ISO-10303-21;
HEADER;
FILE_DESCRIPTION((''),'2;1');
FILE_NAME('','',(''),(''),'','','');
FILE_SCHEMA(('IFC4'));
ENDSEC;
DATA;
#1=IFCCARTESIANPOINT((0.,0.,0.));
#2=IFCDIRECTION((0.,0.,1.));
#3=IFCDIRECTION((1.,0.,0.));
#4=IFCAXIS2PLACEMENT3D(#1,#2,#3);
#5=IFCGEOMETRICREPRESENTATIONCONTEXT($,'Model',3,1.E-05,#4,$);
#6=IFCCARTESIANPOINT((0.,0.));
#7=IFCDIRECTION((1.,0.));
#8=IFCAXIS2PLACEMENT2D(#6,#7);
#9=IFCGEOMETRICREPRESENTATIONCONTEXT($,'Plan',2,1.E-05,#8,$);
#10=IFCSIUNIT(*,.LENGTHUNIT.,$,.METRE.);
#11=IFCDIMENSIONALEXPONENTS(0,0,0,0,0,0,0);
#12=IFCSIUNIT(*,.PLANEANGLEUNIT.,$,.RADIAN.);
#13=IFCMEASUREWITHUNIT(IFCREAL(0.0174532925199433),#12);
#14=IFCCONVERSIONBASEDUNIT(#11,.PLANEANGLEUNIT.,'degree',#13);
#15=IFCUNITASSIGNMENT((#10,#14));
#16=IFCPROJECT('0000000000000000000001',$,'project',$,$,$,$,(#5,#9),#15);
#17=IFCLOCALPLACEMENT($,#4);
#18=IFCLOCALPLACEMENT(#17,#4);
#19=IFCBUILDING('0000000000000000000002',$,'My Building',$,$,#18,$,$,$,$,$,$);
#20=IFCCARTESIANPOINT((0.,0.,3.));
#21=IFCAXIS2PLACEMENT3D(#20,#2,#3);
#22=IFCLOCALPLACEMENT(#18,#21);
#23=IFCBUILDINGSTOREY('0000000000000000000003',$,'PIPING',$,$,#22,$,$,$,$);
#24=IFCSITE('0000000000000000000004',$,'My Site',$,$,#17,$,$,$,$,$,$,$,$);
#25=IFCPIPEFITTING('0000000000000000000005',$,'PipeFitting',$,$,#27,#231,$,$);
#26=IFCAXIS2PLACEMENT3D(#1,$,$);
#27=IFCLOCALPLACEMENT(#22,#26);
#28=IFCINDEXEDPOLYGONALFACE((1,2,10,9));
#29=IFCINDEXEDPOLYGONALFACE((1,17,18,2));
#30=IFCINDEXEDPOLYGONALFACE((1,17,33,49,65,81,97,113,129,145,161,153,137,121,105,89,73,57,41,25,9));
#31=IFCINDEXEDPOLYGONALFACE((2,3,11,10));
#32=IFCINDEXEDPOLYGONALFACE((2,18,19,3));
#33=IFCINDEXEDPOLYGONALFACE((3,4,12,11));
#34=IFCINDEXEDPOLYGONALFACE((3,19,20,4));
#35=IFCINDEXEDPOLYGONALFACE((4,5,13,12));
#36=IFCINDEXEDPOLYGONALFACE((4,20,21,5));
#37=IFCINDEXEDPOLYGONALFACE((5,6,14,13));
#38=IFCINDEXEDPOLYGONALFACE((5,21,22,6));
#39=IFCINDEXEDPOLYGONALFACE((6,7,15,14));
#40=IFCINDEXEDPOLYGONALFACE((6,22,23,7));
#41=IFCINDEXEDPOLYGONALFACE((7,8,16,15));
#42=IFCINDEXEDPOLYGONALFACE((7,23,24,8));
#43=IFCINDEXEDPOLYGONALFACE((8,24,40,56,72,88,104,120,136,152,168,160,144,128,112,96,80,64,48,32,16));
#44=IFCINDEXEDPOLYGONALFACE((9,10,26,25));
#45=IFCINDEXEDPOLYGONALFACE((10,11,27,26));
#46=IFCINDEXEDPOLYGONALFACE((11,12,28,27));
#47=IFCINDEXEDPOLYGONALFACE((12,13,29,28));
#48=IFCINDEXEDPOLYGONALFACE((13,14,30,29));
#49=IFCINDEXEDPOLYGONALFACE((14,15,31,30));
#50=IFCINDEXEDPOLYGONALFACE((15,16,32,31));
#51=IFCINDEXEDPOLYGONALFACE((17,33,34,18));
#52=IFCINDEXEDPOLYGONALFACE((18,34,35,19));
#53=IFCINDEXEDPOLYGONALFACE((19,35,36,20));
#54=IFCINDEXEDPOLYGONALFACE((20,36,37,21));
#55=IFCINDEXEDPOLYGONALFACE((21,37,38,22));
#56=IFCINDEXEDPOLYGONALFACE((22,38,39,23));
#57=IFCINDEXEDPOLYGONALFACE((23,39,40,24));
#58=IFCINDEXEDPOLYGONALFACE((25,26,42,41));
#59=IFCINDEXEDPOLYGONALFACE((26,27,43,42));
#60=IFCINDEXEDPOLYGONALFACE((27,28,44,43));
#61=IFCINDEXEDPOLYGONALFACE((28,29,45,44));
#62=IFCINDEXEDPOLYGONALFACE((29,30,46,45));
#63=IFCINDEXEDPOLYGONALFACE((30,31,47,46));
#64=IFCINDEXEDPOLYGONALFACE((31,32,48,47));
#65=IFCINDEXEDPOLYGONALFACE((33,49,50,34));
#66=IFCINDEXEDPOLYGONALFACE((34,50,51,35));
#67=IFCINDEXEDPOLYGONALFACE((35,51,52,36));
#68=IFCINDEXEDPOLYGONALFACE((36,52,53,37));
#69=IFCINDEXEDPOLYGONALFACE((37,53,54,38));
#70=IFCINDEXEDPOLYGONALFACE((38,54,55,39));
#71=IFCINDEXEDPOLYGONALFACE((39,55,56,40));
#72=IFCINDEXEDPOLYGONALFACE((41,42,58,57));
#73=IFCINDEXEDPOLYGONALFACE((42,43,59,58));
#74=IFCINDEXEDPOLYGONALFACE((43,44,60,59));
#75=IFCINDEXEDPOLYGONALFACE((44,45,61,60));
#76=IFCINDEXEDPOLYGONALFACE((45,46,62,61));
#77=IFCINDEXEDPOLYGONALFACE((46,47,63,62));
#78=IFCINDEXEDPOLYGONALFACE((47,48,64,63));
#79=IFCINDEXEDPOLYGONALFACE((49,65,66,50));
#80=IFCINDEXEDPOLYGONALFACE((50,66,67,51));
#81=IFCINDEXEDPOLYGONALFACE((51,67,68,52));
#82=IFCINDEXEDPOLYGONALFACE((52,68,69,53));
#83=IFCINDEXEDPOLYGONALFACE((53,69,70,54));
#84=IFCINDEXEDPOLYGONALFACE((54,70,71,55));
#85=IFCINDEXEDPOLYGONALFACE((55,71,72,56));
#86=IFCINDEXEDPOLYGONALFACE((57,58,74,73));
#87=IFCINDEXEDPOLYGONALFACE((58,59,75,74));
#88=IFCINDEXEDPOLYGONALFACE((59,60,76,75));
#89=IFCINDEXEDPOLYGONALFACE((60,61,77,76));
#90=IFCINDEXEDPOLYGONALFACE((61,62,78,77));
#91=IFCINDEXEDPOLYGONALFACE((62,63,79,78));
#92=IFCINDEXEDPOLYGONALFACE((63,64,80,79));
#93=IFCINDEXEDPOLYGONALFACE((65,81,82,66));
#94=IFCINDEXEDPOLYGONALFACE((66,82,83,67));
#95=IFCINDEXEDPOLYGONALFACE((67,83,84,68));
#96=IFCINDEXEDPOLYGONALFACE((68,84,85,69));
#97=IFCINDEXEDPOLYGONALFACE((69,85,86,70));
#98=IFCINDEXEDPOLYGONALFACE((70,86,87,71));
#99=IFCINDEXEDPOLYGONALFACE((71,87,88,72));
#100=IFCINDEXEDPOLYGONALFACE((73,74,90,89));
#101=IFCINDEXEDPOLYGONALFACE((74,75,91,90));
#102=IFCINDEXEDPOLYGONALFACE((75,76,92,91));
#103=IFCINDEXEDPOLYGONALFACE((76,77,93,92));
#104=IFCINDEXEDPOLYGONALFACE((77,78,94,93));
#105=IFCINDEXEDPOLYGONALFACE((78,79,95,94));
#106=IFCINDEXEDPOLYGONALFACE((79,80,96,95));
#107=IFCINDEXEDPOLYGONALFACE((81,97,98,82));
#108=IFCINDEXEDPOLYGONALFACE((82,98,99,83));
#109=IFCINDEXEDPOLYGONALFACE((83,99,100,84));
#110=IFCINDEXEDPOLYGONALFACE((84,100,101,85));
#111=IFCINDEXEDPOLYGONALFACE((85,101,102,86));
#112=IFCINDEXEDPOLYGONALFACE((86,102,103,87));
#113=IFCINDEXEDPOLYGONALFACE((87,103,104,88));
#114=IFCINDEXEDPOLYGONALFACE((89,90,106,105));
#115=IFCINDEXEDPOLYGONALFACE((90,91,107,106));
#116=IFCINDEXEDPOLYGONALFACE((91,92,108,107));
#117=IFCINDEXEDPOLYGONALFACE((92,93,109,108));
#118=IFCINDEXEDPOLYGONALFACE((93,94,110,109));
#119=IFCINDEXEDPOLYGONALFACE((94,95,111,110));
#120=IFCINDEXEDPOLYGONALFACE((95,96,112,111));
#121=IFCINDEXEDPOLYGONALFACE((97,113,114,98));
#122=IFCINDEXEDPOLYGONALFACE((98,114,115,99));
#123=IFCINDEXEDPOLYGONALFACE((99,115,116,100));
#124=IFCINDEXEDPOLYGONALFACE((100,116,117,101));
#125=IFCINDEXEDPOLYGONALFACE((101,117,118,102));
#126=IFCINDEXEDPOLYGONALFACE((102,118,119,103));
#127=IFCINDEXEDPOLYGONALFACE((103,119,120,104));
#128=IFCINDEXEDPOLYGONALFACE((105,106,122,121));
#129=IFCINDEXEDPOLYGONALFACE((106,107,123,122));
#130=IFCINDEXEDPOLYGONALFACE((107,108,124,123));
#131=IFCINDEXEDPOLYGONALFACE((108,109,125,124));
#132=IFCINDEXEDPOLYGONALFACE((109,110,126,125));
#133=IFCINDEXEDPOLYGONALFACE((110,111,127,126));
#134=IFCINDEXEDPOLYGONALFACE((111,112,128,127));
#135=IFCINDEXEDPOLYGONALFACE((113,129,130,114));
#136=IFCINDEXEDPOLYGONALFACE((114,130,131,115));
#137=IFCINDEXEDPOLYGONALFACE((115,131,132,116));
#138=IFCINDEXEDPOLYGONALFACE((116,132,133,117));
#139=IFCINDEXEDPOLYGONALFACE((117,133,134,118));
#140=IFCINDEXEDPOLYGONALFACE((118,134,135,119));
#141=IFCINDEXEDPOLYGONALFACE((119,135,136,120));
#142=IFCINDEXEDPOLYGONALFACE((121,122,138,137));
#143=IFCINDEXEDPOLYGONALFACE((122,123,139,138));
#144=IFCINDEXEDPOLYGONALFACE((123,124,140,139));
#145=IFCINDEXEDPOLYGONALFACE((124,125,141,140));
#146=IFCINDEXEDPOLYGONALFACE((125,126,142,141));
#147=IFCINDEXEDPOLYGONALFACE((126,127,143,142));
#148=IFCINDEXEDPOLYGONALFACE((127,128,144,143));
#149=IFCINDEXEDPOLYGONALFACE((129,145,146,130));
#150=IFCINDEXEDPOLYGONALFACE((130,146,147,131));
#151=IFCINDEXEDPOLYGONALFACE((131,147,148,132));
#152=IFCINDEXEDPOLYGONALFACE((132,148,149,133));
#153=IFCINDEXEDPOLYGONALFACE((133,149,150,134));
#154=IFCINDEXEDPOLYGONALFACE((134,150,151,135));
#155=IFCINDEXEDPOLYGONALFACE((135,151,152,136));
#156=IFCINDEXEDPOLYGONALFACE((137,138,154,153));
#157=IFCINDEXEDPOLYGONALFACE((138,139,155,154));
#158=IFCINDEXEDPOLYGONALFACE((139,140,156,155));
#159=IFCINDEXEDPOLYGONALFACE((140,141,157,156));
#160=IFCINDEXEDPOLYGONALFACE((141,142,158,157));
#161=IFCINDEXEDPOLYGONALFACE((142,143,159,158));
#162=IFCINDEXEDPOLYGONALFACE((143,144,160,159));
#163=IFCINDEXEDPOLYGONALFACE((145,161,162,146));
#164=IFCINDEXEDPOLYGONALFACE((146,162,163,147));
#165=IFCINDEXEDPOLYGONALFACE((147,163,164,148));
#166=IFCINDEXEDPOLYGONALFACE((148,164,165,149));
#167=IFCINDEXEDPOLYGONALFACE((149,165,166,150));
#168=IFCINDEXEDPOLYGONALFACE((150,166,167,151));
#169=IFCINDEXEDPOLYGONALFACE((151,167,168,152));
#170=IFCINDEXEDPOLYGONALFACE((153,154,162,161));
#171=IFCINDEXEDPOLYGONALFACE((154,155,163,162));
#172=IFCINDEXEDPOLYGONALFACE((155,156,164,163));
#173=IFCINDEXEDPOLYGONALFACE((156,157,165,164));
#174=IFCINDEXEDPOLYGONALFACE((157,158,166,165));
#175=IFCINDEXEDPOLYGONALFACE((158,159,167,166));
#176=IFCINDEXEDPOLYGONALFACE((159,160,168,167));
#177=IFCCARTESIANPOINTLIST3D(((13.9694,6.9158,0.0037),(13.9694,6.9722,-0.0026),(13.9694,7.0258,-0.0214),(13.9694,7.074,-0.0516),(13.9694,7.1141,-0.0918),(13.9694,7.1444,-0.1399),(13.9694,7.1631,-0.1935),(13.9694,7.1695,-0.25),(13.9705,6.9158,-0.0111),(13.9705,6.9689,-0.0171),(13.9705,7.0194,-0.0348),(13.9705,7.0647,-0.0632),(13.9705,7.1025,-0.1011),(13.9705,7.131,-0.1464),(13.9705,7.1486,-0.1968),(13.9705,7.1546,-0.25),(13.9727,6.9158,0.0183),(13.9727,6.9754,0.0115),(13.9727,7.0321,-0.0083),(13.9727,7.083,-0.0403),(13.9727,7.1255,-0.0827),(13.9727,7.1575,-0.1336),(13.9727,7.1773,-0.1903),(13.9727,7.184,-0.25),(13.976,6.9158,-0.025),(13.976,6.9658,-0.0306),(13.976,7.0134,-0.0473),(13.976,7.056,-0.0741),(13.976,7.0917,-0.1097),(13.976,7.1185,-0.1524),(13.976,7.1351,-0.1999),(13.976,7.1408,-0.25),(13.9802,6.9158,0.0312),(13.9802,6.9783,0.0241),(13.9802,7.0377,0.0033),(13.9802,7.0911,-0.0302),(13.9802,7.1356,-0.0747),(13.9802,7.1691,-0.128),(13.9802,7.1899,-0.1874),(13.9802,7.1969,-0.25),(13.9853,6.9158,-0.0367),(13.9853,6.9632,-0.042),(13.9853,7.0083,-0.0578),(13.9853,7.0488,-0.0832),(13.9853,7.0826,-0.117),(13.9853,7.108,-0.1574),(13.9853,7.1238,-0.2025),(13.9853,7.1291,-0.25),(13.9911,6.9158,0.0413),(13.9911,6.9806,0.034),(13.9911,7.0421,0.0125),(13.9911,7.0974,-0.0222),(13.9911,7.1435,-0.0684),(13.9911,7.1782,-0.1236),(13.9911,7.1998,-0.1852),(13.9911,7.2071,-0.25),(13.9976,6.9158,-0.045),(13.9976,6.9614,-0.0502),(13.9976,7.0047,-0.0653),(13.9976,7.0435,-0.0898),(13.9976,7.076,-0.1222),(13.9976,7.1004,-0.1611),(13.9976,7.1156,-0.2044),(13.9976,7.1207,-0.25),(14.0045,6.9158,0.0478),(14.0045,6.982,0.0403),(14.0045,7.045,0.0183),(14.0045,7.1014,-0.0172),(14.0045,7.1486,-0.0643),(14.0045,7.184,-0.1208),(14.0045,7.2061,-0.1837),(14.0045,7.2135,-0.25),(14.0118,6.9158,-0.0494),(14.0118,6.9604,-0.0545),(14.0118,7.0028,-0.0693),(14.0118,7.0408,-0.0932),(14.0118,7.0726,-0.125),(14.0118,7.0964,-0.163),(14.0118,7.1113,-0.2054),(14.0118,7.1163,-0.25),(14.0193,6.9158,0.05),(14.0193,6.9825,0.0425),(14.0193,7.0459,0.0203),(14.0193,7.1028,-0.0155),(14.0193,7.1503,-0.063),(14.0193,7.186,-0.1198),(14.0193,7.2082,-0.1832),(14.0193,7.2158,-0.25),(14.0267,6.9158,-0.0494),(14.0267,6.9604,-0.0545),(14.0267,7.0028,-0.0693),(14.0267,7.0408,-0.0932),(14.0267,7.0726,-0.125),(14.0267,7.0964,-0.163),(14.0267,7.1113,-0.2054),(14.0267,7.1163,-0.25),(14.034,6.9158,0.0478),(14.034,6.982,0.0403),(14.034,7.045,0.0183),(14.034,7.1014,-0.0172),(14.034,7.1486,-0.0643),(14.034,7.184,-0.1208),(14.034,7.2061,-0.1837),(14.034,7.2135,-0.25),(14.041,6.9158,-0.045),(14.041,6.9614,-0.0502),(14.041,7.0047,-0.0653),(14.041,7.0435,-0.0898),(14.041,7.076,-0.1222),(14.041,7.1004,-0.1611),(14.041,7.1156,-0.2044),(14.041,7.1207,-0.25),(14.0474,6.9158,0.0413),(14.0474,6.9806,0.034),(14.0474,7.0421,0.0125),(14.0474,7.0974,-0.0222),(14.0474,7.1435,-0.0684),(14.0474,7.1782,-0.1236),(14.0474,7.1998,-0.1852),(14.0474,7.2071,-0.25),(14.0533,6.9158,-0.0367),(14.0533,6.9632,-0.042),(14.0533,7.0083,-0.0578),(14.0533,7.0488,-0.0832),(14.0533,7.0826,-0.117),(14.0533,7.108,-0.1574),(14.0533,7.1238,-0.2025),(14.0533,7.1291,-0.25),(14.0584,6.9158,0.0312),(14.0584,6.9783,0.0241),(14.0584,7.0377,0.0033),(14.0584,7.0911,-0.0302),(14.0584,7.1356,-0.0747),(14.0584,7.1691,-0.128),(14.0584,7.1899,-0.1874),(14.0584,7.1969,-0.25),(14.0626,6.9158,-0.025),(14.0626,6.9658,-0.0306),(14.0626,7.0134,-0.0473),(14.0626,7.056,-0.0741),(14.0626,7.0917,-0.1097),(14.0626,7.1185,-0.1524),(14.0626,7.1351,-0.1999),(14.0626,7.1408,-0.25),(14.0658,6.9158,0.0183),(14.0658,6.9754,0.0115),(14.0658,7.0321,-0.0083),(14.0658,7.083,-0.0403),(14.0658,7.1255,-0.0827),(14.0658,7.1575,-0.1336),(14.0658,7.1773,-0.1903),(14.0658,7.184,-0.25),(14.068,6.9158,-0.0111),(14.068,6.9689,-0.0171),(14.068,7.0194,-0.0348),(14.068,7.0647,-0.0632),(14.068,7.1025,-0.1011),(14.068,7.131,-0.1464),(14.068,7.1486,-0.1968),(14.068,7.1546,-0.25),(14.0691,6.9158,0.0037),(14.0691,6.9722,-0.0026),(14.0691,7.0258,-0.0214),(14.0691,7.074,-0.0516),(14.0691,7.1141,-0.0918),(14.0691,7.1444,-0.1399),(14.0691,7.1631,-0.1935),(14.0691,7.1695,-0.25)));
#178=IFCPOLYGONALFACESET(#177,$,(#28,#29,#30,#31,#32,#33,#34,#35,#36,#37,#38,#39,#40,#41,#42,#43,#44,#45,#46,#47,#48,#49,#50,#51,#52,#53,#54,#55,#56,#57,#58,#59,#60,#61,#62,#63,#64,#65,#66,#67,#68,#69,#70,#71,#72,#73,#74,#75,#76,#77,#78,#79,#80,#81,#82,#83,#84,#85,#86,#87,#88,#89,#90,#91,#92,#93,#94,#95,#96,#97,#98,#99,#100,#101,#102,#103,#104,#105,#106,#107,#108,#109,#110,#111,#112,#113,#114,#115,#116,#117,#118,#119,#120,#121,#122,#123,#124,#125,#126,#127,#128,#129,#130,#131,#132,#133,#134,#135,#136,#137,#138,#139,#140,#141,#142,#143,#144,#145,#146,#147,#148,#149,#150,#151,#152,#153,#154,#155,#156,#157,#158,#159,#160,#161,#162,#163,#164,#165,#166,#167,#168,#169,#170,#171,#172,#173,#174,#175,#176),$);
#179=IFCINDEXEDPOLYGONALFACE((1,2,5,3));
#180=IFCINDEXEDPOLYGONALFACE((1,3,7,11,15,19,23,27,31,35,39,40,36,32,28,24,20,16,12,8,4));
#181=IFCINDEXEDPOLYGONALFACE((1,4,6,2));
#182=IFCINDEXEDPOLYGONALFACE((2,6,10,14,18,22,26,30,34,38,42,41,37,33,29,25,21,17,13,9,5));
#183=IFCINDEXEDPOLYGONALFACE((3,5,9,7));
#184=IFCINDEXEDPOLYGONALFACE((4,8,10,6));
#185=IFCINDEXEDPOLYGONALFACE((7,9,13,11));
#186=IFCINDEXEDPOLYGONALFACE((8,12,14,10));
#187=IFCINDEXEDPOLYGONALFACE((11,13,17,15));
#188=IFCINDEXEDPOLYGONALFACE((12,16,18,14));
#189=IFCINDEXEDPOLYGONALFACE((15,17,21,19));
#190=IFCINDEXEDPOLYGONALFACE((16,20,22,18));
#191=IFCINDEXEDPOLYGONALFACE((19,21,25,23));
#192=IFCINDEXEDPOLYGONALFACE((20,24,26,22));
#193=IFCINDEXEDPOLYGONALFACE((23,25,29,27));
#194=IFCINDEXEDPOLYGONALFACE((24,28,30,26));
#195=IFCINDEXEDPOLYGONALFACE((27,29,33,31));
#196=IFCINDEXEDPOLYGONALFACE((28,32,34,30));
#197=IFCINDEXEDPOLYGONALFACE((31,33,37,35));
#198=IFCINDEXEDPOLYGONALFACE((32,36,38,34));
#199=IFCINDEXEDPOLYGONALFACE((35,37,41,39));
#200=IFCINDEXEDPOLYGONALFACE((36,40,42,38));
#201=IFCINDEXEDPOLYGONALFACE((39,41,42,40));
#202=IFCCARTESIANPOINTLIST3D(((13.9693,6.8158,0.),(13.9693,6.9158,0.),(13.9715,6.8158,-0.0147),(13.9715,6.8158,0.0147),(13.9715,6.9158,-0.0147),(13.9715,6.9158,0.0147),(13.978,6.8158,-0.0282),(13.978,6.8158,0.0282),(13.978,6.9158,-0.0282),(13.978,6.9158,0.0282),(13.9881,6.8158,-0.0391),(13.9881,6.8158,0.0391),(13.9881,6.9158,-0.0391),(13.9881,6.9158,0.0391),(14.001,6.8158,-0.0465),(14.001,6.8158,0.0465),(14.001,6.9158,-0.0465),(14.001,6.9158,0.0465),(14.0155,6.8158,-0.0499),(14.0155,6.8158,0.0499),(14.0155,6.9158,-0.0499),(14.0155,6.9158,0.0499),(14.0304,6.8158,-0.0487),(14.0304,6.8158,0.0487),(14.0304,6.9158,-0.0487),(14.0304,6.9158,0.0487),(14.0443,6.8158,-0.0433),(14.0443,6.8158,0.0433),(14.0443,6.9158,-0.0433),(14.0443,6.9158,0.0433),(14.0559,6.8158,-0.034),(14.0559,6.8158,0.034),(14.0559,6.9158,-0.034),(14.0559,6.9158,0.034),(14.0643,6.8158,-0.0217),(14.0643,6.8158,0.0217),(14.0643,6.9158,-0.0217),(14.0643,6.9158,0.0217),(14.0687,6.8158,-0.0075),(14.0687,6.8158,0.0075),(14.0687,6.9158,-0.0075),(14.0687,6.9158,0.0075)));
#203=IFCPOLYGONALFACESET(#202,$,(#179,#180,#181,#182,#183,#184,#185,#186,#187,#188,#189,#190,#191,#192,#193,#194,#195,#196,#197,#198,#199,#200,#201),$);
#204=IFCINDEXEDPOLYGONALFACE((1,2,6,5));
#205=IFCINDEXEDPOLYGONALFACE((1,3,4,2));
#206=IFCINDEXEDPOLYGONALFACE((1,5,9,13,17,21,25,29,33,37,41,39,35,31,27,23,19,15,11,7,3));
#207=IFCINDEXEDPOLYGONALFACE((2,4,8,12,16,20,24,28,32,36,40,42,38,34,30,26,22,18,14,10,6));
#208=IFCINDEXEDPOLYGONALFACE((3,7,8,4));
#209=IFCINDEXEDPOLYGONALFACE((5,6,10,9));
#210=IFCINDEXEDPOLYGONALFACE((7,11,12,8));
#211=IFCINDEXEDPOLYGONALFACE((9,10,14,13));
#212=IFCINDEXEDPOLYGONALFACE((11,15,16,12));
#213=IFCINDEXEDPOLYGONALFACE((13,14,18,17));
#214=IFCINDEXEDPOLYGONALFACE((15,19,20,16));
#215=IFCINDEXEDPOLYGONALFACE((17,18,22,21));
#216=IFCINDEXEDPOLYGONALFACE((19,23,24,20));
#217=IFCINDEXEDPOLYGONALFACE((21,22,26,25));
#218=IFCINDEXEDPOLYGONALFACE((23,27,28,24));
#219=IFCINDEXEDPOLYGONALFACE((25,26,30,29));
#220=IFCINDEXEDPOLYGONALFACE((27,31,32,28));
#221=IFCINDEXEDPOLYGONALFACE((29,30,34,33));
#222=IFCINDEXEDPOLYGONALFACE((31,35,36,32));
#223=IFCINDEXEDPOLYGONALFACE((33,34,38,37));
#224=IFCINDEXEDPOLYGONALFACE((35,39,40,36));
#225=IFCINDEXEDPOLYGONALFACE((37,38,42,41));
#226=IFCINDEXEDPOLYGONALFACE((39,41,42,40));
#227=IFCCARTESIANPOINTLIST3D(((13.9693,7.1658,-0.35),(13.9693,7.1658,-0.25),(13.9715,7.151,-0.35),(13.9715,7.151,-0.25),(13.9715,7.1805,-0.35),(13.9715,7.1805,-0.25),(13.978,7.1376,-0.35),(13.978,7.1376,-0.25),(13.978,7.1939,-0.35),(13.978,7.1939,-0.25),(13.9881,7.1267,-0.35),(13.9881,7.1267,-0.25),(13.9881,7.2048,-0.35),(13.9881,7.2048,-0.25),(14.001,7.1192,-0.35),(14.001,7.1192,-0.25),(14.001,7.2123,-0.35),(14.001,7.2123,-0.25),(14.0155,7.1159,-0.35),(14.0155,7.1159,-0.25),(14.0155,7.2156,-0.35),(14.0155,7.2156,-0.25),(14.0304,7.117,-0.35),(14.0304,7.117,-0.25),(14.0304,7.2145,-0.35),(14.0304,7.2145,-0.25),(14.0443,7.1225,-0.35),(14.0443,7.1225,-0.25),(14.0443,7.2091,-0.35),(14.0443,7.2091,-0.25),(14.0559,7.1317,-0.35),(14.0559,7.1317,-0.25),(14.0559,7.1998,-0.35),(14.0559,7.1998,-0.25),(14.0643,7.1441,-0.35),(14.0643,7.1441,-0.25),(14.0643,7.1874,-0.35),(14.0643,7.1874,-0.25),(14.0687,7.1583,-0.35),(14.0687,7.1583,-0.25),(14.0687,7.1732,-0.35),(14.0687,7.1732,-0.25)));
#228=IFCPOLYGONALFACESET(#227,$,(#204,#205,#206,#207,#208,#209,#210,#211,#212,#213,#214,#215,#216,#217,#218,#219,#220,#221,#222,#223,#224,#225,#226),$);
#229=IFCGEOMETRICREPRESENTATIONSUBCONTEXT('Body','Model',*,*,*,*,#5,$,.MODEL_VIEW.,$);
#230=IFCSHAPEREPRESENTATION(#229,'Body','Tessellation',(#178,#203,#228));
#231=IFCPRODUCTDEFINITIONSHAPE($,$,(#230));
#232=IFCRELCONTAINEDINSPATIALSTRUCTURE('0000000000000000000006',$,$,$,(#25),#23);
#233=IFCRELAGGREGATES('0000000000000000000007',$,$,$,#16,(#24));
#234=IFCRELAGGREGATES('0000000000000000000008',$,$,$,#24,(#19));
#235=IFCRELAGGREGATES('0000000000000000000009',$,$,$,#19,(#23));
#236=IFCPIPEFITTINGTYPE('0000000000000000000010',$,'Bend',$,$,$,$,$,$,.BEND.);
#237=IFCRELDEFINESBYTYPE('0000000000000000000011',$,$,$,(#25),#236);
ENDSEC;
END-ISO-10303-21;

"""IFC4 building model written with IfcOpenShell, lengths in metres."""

from ifc_helpers import new_model, entity, si_unit, converted_unit, frame, origin_with_axes, origin_2d_with_axis, place, context, subcontext, project, spatial, line, indexed_curve, circle, outline, extrude, source, transform, mapped, type_object, type_shapes, element, save


model = new_model("IFC4")

# Units and contexts
model_context = context("Model", 3, precision=1e-05, world=origin_with_axes())
plan_context = context("Plan", 2, precision=1e-05, world=origin_2d_with_axis())
body_context = subcontext(model_context, "Body", "Model", "MODEL_VIEW")
ifc_project = project(units=[si_unit("LENGTHUNIT", "METRE"), converted_unit("PLANEANGLEUNIT", "degree", entity("IfcReal", 0.0174532925199433), si_unit("PLANEANGLEUNIT", "RADIAN"), dimensions=[0, 0, 0, 0, 0, 0, 0])], contexts=[model_context, plan_context])

# Site, building, storey
site_placement = place(None, origin_with_axes())
site = spatial("IfcSite", under=ifc_project, at=site_placement, Name="My Site")
building_placement = place(site_placement, origin_with_axes())
building = spatial("IfcBuilding", under=site, at=building_placement, Name="My Building")
storey_placement = place(building_placement, frame((0.0, 0.0, 3.0), z_axis=(0.0, 0.0, 1.0), x_axis=(1.0, 0.0, 0.0)))
storey = spatial("IfcBuildingStorey", under=building, at=storey_placement, Name="PIPING")

# Pipe fitting, opening
pipe_fitting_type = type_object("IfcPipeFittingType", Name="Bend", PredefinedType="BEND")
shared_shape = source(origin_with_axes(), body_context, "Body", "SolidModel", [
    entity("IfcSweptDiskSolid", entity("IfcIndexedPolyCurve", entity("IfcCartesianPointList3D", [[0.0, 0.0, 0.1], [0.0, -0.0732, 0.2768], [0.0, -0.25, 0.35]]), [entity("IfcArcIndex", [1, 2, 3])]), 0.05),
    extrude(circle(Radius=0.05), origin_with_axes(), (0.0, 0.0, 1.0), 0.1),
    extrude(circle(Radius=0.05), frame((0.0, -0.25, 0.35), z_axis=(0.0, -1.0, 0.0), x_axis=(1.0, 0.0, 0.0)), (0.0, 0.0, 1.0), 0.1),
])
type_shapes(pipe_fitting_type, [shared_shape])
pipe_fitting_1_placement = place(storey_placement, frame((14.0193, 6.8158, 0.0), z_axis=(0.0, 1.0, 0.0), x_axis=(-1.0, 0.0, 0.0)))
pipe_fitting_1 = element("IfcPipeFitting", 1, at=pipe_fitting_1_placement, inside=storey, type_object=pipe_fitting_type, Name="PipeFitting", context=body_context, shape_type="MappedRepresentation", body=[
    mapped(shared_shape, transform((0.0, 0.0, 0.0), x_axis=(1.0, 0.0, 0.0), y_axis=(0.0, 1.0, 0.0), z_axis=(0.0, 0.0, 1.0), scale=1.0)),
])
opening_1_placement = place(pipe_fitting_1_placement, frame((14.0193, -3.0, -6.8158), z_axis=(0.0, 1.0, 0.0), x_axis=(-1.0, 0.0, 0.0)))
element("IfcOpeningElement", 2, at=opening_1_placement, cuts=pipe_fitting_1, PredefinedType="OPENING", context=body_context, shape_type="SweptSolid", body=[
    extrude(outline(indexed_curve([(0.0, 0.0), (0.5, 0.0), (0.5, 0.5), (0.0, 0.5)], segments=[line(1, 2, 3, 4, 1)])), origin_with_axes(), (0.0, 0.0, 1.0), 0.5),
])

save(model, "model.ifc")
